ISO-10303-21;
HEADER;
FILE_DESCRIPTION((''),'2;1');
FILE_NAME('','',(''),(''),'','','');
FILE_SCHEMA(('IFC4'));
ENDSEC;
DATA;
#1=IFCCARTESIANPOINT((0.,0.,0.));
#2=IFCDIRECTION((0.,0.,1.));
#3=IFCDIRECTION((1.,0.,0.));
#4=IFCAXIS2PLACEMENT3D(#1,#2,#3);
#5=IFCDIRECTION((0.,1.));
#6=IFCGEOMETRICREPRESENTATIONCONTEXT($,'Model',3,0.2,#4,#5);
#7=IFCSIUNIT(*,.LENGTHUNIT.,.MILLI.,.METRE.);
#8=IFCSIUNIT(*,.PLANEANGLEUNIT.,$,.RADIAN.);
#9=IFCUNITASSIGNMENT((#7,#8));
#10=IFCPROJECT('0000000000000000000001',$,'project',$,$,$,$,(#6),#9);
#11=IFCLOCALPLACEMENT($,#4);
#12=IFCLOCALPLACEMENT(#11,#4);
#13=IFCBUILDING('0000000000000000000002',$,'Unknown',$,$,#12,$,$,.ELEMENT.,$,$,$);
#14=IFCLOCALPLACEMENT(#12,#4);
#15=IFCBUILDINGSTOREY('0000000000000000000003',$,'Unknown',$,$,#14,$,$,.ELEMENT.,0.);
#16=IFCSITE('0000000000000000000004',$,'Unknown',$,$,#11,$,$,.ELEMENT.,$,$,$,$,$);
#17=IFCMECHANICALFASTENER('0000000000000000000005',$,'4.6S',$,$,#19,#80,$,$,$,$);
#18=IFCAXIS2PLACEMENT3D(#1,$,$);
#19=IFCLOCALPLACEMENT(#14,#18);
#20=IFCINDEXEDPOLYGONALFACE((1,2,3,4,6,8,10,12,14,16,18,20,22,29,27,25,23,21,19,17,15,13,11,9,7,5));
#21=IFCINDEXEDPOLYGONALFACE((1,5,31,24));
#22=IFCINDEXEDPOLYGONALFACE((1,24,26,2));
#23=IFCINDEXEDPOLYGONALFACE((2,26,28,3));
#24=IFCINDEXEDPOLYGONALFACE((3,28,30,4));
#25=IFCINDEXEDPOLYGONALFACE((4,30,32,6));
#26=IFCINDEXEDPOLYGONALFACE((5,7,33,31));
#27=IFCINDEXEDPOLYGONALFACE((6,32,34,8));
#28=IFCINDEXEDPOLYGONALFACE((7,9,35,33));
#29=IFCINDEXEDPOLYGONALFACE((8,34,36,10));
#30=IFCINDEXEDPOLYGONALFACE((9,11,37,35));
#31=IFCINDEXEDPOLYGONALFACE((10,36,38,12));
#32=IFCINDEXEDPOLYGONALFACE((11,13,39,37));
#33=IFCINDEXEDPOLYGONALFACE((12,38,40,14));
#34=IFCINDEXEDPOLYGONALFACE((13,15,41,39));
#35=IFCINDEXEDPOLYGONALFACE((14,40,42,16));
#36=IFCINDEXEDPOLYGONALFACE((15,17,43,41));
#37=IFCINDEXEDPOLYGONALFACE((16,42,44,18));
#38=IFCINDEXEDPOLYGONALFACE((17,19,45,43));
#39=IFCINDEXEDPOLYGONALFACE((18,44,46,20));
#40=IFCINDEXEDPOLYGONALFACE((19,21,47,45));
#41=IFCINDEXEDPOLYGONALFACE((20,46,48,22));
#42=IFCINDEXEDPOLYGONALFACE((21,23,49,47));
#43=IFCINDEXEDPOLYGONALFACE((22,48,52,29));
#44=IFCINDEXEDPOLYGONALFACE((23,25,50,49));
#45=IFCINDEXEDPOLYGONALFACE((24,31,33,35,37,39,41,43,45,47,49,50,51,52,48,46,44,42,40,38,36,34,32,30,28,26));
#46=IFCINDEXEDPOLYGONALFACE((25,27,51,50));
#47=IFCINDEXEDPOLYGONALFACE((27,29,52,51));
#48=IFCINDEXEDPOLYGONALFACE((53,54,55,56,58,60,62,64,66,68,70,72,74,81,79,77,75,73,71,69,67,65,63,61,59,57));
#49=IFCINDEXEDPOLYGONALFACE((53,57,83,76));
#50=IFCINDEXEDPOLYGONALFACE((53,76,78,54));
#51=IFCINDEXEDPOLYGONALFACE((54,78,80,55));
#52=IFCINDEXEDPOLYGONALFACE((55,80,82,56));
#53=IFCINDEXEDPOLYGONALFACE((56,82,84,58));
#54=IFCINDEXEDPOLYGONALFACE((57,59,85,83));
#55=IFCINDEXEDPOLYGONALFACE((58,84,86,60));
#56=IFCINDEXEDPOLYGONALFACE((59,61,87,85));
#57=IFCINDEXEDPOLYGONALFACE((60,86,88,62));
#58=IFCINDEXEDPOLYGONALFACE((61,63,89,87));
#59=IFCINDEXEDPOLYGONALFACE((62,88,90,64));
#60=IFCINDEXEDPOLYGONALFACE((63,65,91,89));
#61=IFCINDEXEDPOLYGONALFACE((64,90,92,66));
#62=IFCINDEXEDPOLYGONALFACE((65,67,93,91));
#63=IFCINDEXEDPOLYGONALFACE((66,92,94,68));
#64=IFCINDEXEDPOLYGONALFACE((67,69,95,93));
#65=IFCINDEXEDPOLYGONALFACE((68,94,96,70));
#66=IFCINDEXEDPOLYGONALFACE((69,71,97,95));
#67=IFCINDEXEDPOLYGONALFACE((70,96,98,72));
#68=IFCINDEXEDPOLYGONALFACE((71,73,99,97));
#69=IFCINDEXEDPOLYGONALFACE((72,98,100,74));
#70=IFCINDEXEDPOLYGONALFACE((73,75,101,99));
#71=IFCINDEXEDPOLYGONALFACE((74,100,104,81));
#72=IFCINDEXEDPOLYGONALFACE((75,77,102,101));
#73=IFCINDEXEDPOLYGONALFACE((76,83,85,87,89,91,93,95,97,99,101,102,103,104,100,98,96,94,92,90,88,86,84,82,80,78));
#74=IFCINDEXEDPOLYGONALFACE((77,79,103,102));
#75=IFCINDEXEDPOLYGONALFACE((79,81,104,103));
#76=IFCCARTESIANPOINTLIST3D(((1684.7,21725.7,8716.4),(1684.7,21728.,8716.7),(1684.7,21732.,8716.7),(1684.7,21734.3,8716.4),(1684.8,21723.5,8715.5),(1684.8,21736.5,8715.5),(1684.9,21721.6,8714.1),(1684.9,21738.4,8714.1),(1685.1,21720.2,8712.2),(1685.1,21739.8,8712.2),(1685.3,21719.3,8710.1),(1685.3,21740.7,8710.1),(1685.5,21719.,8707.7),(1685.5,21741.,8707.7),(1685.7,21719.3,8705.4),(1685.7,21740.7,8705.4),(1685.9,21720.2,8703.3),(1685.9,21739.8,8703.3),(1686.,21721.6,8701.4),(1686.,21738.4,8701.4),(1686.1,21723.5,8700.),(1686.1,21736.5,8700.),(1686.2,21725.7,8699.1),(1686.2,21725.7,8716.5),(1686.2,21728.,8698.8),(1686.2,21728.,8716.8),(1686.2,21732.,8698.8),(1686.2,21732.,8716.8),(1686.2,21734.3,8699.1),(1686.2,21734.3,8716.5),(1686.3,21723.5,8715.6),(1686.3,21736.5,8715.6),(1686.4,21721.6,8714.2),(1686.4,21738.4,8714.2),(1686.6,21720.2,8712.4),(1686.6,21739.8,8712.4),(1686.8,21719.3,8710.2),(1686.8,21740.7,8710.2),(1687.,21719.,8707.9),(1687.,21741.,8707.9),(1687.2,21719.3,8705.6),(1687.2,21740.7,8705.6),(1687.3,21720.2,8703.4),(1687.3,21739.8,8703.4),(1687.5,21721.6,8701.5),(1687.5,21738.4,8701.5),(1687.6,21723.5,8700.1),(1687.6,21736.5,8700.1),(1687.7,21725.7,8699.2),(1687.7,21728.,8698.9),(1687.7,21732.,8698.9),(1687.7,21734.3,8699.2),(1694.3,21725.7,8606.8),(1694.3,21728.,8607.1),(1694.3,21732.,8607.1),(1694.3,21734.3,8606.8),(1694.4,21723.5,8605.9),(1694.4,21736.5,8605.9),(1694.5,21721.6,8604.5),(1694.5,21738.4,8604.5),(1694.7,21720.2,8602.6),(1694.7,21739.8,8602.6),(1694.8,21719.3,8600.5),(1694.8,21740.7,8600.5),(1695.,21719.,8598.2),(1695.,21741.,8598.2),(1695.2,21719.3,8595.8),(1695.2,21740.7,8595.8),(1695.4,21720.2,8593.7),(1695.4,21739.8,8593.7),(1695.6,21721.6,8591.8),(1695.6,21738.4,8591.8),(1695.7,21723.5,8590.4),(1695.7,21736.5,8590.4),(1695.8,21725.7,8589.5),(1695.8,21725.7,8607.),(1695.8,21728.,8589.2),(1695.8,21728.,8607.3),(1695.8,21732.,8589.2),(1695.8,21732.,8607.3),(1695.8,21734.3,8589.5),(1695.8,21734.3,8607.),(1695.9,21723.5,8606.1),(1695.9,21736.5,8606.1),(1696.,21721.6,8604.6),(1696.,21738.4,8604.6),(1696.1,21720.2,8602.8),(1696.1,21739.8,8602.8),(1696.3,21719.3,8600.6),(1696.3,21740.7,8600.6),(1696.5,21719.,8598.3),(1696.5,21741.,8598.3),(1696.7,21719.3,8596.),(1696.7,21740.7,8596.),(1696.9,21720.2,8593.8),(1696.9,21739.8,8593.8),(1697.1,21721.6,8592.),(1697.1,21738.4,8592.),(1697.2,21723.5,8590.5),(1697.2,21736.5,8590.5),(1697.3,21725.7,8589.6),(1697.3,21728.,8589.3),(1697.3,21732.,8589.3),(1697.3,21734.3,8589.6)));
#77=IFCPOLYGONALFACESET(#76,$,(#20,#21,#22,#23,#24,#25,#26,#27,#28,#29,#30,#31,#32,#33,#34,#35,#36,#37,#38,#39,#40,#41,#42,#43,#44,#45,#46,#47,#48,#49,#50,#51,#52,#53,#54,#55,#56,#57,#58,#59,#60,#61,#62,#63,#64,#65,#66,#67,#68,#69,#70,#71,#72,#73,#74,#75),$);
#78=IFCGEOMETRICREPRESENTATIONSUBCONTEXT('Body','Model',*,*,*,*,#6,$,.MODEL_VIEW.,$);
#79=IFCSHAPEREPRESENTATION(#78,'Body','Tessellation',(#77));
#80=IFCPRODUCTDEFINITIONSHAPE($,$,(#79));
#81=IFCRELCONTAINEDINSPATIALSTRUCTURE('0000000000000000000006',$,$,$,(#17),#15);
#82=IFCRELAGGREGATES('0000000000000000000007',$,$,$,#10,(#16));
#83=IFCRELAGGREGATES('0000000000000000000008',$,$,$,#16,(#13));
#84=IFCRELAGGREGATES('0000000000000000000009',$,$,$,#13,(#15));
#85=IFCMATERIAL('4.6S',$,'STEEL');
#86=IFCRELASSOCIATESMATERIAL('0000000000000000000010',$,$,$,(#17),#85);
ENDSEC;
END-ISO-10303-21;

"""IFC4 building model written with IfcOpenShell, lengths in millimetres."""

from ifc_helpers import new_model, si_unit, direction, frame, origin_with_axes, place, context, subcontext, project, spatial, line, arc, indexed_curve, outline, extrude, source, transform, mapped, material, element, save


model = new_model("IFC4")

# Units and contexts
model_context = context("Model", 3, precision=0.2, world=origin_with_axes(), true_north=direction((0.0, 1.0)))
body_context = subcontext(model_context, "Body", "Model", "MODEL_VIEW")
ifc_project = project(units=[si_unit("LENGTHUNIT", "METRE", prefix="MILLI"), si_unit("PLANEANGLEUNIT", "RADIAN")], contexts=[model_context])

# Site, building, storey
site_placement = place(None, origin_with_axes())
site = spatial("IfcSite", under=ifc_project, at=site_placement, Name="Unknown", CompositionType="ELEMENT")
building_placement = place(site_placement, origin_with_axes())
building = spatial("IfcBuilding", under=site, at=building_placement, Name="Unknown", CompositionType="ELEMENT")
storey_placement = place(building_placement, origin_with_axes())
storey = spatial("IfcBuildingStorey", under=building, at=storey_placement, Name="Unknown", CompositionType="ELEMENT", Elevation=0.0)

# Mechanical fastener
ifc_material_1 = material(Name="4.6S", Category="STEEL")
shared_shape_1 = source(origin_with_axes(), body_context, "Body", "SweptSolid", [
    extrude(outline(indexed_curve([(-2.0, 9.0), (2.0, 9.0), (2.0, 9.0), (8.4, 6.4), (11.0, 0.0), (8.4, -6.4), (2.0, -9.0), (-2.0, -9.0), (-2.8, -9.0), (-11.0, 0.0), (-8.4, 6.4)], segments=[line(1, 2, 3), arc(3, 4, 5), arc(5, 6, 7), line(7, 8), arc(8, 9, 10), arc(10, 11, 1)])), frame((0.0, 0.0, 0.7), z_axis=(0.0, 0.0, -1.0), x_axis=(0.0, 1.0, 0.0)), (0.0, 0.0, 1.0), 1.5),
])
mechanical_fastener_1_placement = place(storey_placement, frame((1695.8, 21730.0, 8598.2), z_axis=(-0.996195, 0.0, -0.087155), x_axis=(-0.087155, 0.0, 0.996195)))
element("IfcMechanicalFastener", 1, at=mechanical_fastener_1_placement, inside=storey, material=ifc_material_1, Name="4.6S", context=body_context, shape_type="MappedRepresentation", body=[
    mapped(shared_shape_1, transform((0.0, 0.0, 0.0))),
    mapped(shared_shape_1, transform((110.0, 0.0, 0.0))),
])

save(model, "model.ifc")
